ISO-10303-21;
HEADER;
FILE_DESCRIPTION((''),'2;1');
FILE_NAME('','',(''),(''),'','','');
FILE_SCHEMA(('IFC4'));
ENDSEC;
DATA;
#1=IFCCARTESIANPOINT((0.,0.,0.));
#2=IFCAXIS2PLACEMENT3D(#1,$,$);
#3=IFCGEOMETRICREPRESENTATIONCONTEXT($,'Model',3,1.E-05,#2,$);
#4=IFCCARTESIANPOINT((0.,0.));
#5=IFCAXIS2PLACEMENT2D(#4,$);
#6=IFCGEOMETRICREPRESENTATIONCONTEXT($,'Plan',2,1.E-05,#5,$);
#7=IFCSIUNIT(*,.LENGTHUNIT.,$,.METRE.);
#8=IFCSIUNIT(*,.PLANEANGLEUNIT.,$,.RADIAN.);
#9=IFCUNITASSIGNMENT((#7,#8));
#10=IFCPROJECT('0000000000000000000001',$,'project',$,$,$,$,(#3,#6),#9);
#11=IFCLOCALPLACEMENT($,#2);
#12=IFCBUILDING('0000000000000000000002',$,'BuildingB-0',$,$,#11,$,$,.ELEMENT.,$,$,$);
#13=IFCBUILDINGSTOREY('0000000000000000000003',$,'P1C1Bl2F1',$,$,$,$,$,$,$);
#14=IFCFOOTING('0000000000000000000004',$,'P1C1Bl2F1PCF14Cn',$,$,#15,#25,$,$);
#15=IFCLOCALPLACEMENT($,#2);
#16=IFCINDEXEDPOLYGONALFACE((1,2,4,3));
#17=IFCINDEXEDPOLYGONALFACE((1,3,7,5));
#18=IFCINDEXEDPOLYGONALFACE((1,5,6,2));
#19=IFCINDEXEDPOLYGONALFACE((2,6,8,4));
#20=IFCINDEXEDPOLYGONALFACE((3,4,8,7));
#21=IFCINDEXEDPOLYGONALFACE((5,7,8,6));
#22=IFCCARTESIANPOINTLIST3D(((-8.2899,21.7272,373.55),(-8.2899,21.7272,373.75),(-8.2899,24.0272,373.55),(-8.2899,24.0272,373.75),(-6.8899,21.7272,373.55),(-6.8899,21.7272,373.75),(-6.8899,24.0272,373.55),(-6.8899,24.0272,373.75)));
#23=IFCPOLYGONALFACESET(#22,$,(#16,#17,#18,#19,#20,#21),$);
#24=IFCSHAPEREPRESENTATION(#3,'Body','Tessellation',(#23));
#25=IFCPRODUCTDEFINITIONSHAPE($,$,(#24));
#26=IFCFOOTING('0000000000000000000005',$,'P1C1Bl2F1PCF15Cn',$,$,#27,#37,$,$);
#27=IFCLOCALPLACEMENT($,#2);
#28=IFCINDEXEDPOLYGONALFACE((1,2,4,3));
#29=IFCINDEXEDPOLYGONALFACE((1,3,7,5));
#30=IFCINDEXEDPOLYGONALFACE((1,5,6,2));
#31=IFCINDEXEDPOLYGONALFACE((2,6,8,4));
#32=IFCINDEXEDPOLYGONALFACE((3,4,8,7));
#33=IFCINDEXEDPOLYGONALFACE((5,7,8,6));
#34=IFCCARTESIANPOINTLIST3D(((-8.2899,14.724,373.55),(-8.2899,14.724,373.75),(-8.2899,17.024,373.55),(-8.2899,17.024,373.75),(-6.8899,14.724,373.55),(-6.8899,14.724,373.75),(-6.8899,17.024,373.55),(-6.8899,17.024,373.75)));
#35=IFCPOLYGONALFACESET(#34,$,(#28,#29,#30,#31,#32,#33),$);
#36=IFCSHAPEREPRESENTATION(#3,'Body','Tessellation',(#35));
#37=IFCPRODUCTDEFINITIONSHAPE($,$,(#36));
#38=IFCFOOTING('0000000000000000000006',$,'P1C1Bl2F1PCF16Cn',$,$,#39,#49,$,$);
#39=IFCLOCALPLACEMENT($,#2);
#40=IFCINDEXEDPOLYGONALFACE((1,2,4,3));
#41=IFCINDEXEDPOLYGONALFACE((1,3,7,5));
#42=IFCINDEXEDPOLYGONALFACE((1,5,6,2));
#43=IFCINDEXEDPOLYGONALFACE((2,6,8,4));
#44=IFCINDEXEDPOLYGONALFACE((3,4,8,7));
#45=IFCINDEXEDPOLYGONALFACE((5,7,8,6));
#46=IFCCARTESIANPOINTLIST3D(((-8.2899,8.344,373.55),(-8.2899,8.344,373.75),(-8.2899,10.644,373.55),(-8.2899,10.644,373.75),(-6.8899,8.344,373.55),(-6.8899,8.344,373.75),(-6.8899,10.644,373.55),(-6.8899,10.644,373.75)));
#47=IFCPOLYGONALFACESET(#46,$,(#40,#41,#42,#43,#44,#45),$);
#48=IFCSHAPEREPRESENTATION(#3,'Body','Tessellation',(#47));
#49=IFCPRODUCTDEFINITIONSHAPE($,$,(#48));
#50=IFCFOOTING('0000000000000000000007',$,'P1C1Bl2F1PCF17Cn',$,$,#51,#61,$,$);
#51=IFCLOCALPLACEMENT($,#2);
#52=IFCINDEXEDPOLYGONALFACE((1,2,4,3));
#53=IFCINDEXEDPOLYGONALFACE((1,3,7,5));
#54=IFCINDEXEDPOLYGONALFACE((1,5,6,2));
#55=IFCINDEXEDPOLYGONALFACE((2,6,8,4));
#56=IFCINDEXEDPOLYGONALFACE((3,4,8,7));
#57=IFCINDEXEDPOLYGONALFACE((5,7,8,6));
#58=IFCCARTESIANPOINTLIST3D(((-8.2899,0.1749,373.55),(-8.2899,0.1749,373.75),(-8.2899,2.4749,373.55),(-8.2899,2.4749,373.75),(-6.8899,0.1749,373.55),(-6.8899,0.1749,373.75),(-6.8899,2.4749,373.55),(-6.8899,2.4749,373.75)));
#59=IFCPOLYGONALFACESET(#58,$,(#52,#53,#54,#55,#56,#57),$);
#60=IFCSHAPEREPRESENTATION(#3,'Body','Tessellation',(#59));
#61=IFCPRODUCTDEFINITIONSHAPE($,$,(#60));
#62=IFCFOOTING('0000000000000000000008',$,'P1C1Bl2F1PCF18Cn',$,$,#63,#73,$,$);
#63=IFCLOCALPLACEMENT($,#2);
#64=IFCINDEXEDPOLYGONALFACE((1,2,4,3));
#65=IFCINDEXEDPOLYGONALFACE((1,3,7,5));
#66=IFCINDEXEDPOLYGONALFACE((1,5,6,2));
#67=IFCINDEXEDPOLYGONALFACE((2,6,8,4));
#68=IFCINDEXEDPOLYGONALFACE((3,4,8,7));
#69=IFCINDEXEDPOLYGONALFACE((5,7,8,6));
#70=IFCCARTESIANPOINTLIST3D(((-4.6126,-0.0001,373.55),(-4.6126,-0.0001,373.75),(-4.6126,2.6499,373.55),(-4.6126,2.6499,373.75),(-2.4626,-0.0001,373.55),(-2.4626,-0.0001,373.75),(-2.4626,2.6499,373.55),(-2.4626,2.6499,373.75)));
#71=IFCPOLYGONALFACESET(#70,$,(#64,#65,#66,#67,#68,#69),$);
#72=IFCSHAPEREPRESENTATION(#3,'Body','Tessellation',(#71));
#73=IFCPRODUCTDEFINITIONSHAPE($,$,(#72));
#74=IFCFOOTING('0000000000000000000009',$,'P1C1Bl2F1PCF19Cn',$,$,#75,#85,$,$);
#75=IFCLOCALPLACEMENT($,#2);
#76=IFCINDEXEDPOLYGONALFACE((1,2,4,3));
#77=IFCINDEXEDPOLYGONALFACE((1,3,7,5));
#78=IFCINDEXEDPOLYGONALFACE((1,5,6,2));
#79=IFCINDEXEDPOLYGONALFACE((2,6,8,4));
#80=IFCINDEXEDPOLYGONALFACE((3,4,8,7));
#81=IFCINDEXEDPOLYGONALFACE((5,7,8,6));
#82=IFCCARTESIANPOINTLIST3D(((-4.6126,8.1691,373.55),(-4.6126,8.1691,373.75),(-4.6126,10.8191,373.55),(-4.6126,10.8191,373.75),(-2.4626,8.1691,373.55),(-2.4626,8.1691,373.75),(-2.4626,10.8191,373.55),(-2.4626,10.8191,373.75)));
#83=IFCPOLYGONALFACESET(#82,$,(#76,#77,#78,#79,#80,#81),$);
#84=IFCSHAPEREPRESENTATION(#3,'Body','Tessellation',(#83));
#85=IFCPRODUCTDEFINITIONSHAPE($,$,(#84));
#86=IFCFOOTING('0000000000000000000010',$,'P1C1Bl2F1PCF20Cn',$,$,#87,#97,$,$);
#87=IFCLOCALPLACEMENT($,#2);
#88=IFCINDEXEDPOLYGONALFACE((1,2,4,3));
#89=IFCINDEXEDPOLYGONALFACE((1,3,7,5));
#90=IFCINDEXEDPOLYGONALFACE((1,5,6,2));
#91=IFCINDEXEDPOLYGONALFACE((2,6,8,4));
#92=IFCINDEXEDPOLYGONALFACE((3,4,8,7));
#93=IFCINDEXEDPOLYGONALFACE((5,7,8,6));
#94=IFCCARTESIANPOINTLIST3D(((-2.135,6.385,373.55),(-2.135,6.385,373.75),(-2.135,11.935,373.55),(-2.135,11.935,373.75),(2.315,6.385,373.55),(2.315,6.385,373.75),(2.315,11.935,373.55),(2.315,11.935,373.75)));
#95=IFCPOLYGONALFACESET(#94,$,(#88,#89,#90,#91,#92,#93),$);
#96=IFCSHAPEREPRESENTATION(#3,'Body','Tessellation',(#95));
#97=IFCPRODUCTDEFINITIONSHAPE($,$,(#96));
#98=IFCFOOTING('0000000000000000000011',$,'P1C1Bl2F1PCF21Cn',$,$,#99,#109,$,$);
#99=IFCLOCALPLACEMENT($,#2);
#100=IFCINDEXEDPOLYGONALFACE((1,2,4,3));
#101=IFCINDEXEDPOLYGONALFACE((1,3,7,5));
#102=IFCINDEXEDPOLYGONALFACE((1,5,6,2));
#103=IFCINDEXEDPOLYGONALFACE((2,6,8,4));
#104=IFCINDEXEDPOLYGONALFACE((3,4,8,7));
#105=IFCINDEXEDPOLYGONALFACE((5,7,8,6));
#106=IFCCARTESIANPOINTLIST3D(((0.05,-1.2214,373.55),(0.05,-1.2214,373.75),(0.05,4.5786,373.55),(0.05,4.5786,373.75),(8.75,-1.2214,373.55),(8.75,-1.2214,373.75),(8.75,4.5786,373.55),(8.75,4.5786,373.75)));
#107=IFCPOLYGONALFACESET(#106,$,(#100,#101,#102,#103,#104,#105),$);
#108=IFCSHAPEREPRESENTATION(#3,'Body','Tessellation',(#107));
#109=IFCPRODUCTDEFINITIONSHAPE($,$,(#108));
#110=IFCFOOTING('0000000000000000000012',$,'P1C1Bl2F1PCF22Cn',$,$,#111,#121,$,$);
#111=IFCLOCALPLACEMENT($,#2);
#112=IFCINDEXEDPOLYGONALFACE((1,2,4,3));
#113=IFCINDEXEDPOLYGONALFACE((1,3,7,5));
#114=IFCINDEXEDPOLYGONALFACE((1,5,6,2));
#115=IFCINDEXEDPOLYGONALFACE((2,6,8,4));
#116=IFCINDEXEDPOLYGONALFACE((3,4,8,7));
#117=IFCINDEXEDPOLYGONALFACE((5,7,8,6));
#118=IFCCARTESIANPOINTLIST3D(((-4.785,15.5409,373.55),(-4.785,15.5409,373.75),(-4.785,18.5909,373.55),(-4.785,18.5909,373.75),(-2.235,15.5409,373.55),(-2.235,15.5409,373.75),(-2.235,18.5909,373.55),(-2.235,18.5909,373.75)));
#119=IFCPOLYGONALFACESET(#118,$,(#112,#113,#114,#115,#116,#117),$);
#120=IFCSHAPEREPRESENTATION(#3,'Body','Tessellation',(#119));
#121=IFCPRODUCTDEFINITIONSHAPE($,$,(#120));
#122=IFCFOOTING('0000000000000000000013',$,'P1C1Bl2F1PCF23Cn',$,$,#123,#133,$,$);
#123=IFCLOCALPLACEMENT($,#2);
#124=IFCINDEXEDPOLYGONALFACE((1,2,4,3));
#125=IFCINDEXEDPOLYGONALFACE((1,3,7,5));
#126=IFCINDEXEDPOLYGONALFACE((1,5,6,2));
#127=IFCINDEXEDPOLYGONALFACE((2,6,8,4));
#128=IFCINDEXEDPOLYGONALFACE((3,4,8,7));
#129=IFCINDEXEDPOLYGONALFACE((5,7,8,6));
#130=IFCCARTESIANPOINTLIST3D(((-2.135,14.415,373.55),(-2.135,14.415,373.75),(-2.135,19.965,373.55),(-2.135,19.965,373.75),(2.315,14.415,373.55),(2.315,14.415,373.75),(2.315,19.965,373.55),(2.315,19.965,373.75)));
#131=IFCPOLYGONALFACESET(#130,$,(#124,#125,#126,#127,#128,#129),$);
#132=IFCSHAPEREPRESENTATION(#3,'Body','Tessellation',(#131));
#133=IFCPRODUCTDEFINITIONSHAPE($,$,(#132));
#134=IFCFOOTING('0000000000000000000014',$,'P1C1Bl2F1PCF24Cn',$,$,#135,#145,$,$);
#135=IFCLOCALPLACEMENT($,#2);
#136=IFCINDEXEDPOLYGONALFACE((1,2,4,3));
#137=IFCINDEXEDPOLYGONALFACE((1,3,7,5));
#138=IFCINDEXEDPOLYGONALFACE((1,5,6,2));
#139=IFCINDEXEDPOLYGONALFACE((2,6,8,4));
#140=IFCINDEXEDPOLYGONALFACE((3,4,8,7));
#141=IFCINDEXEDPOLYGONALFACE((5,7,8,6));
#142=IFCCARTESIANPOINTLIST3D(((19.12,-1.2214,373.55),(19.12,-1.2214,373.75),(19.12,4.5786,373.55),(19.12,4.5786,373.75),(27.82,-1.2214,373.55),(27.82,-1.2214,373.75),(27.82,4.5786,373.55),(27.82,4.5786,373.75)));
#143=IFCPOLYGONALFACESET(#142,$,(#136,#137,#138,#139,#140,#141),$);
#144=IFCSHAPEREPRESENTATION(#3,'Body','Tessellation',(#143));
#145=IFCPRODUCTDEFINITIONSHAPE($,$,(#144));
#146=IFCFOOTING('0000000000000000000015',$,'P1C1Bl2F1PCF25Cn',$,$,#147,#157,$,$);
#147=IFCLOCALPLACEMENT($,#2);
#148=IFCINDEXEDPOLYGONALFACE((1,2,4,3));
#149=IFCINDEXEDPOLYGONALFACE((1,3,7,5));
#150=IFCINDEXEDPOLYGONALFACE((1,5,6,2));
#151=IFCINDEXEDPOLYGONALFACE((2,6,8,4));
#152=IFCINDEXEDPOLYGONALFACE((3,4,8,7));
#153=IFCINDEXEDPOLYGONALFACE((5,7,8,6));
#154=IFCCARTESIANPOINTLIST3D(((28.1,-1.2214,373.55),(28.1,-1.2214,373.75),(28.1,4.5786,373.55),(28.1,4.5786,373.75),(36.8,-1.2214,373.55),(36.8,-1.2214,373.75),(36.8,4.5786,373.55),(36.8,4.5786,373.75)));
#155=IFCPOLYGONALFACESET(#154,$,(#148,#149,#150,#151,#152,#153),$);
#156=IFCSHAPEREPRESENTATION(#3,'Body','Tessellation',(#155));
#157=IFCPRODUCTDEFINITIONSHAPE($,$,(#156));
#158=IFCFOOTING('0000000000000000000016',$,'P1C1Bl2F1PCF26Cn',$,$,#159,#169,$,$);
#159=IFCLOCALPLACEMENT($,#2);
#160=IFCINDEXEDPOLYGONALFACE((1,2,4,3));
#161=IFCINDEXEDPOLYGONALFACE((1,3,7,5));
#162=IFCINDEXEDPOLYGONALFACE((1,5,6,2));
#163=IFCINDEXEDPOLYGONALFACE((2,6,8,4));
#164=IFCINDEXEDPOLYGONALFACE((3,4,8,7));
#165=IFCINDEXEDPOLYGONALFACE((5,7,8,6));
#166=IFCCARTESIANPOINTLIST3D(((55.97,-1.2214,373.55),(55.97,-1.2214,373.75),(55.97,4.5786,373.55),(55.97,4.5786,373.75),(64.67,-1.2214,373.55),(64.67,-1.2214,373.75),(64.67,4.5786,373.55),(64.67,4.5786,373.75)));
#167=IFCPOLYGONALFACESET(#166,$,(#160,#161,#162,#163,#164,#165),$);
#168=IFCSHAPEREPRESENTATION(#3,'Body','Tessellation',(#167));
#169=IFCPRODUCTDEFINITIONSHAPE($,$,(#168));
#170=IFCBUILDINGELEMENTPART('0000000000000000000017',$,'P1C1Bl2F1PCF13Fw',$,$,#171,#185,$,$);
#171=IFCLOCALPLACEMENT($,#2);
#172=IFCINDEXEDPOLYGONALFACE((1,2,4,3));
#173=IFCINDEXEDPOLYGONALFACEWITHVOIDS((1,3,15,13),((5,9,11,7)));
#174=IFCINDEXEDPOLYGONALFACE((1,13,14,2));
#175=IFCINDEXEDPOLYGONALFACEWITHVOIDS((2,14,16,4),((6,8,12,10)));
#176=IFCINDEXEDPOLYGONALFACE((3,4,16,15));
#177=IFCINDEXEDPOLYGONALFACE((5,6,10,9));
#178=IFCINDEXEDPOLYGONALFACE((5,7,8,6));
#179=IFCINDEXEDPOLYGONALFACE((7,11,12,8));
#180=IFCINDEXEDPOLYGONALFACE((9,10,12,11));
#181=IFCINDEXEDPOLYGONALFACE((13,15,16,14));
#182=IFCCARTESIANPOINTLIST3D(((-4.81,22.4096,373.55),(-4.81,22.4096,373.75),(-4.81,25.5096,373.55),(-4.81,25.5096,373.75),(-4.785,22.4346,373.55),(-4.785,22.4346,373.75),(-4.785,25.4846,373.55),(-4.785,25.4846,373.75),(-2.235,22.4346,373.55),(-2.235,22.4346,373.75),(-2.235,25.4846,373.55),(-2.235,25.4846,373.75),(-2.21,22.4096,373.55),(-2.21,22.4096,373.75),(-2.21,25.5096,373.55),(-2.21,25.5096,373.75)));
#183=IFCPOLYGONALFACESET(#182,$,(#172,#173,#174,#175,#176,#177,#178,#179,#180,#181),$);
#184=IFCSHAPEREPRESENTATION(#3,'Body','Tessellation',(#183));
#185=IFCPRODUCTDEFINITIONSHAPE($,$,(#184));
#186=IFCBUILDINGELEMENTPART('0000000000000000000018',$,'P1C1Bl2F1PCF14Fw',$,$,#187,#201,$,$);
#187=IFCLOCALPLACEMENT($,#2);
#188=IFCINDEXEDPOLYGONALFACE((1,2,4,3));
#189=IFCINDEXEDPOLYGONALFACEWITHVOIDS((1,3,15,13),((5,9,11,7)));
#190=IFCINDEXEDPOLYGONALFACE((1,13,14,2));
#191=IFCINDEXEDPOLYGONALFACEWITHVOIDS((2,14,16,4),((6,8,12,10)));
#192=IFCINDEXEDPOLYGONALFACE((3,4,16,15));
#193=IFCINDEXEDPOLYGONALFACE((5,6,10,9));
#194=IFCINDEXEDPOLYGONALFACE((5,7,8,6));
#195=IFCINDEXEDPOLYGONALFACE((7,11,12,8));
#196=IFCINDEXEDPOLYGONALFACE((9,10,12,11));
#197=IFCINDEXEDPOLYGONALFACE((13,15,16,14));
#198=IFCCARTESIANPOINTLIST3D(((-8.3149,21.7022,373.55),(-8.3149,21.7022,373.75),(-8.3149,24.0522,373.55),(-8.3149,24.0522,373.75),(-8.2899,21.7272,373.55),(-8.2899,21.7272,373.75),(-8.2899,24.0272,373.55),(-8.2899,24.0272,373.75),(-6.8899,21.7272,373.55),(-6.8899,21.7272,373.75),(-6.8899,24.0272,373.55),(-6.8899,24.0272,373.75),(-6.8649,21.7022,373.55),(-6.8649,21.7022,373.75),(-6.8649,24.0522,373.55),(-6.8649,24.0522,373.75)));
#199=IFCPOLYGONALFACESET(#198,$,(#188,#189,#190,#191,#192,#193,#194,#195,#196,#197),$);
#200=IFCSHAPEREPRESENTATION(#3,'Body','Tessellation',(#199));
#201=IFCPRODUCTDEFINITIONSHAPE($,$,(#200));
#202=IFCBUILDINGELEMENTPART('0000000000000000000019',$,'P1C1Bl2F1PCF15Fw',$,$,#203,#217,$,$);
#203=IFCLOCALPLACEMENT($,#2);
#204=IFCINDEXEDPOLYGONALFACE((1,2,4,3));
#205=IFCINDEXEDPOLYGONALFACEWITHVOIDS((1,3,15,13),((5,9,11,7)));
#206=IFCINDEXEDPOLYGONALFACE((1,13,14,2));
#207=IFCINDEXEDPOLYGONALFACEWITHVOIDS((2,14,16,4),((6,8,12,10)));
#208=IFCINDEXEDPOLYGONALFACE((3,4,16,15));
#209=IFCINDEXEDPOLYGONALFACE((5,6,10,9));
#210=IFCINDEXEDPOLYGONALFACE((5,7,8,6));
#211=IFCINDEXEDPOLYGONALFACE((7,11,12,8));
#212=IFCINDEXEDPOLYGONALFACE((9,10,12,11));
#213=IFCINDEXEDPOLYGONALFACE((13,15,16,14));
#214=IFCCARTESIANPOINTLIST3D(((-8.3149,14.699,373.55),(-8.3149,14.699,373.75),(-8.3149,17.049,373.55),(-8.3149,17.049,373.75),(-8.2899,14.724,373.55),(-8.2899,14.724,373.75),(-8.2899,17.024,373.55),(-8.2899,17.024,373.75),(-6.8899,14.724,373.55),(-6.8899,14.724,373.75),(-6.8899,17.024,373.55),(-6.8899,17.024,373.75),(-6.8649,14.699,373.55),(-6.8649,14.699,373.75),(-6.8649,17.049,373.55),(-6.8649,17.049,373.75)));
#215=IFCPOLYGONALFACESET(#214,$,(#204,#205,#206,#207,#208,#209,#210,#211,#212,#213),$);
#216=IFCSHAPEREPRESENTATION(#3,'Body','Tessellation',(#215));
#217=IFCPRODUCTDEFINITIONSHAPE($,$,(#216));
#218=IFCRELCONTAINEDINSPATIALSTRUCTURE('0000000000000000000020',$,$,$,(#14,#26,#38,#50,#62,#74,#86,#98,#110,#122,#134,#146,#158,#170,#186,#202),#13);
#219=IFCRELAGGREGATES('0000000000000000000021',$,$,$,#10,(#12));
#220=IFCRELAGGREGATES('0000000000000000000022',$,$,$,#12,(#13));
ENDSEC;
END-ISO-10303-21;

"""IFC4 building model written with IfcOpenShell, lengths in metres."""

from ifc_helpers import new_model, si_unit, origin, origin_2d, place, context, project, spatial, polyline, outline, extrude, element, save


model = new_model("IFC4")

# Units and contexts
model_context = context("Model", 3, precision=1e-05, world=origin())
plan_context = context("Plan", 2, precision=1e-05, world=origin_2d())
ifc_project = project(units=[si_unit("LENGTHUNIT", "METRE"), si_unit("PLANEANGLEUNIT", "RADIAN")], contexts=[model_context, plan_context])

# Building, storey
building_placement = place(None, origin())
building = spatial("IfcBuilding", under=ifc_project, at=building_placement, Name="BuildingB-0", CompositionType="ELEMENT")
storey = spatial("IfcBuildingStorey", under=building, Name="P1C1Bl2F1")

# Footings
element("IfcFooting", 1, inside=storey, Name="P1C1Bl2F1PCF14Cn", context=model_context, shape_type="SweptSolid", body=[
    extrude(outline(polyline([(-6.8899, 24.0272, 373.55), (-8.2899, 24.0272, 373.55), (-8.2899, 21.7272, 373.55), (-6.8899, 21.7272, 373.55), (-6.8899, 24.0272, 373.55)])), None, (0.0, 0.0, 1.0), 0.2),
])
element("IfcFooting", 2, inside=storey, Name="P1C1Bl2F1PCF15Cn", context=model_context, shape_type="SweptSolid", body=[
    extrude(outline(polyline([(-8.2899, 14.724, 373.55), (-6.8899, 14.724, 373.55), (-6.8899, 17.024, 373.55), (-8.2899, 17.024, 373.55), (-8.2899, 14.724, 373.55)])), None, (0.0, 0.0, 1.0), 0.2),
])
element("IfcFooting", 3, inside=storey, Name="P1C1Bl2F1PCF16Cn", context=model_context, shape_type="SweptSolid", body=[
    extrude(outline(polyline([(-8.2899, 8.344, 373.55), (-6.8899, 8.344, 373.55), (-6.8899, 10.644, 373.55), (-8.2899, 10.644, 373.55), (-8.2899, 8.344, 373.55)])), None, (0.0, 0.0, 1.0), 0.2),
])
element("IfcFooting", 4, inside=storey, Name="P1C1Bl2F1PCF17Cn", context=model_context, shape_type="SweptSolid", body=[
    extrude(outline(polyline([(-8.2899, 0.1749, 373.55), (-6.8899, 0.1749, 373.55), (-6.8899, 2.4749, 373.55), (-8.2899, 2.4749, 373.55), (-8.2899, 0.1749, 373.55)])), None, (0.0, 0.0, 1.0), 0.2),
])
element("IfcFooting", 5, inside=storey, Name="P1C1Bl2F1PCF18Cn", context=model_context, shape_type="SweptSolid", body=[
    extrude(outline(polyline([(-4.6126, -0.0001, 373.55), (-2.4626, -0.0001, 373.55), (-2.4626, 2.6499, 373.55), (-4.6126, 2.6499, 373.55), (-4.6126, -0.0001, 373.55)])), None, (0.0, 0.0, 1.0), 0.2),
])
element("IfcFooting", 6, inside=storey, Name="P1C1Bl2F1PCF19Cn", context=model_context, shape_type="SweptSolid", body=[
    extrude(outline(polyline([(-4.6126, 8.1691, 373.55), (-2.4626, 8.1691, 373.55), (-2.4626, 10.8191, 373.55), (-4.6126, 10.8191, 373.55), (-4.6126, 8.1691, 373.55)])), None, (0.0, 0.0, 1.0), 0.2),
])
element("IfcFooting", 7, inside=storey, Name="P1C1Bl2F1PCF20Cn", context=model_context, shape_type="SweptSolid", body=[
    extrude(outline(polyline([(-2.135, 6.385, 373.55), (2.315, 6.385, 373.55), (2.315, 11.935, 373.55), (-2.135, 11.935, 373.55), (-2.135, 6.385, 373.55)])), None, (0.0, 0.0, 1.0), 0.2),
])
element("IfcFooting", 8, inside=storey, Name="P1C1Bl2F1PCF21Cn", context=model_context, shape_type="SweptSolid", body=[
    extrude(outline(polyline([(0.05, -1.2214, 373.55), (8.75, -1.2214, 373.55), (8.75, 4.5786, 373.55), (0.05, 4.5786, 373.55), (0.05, -1.2214, 373.55)])), None, (0.0, 0.0, 1.0), 0.2),
])
element("IfcFooting", 9, inside=storey, Name="P1C1Bl2F1PCF22Cn", context=model_context, shape_type="SweptSolid", body=[
    extrude(outline(polyline([(-4.785, 15.5409, 373.55), (-2.235, 15.5409, 373.55), (-2.235, 18.5909, 373.55), (-4.785, 18.5909, 373.55), (-4.785, 15.5409, 373.55)])), None, (0.0, 0.0, 1.0), 0.2),
])
element("IfcFooting", 10, inside=storey, Name="P1C1Bl2F1PCF23Cn", context=model_context, shape_type="SweptSolid", body=[
    extrude(outline(polyline([(-2.135, 14.415, 373.55), (2.315, 14.415, 373.55), (2.315, 19.965, 373.55), (-2.135, 19.965, 373.55), (-2.135, 14.415, 373.55)])), None, (0.0, 0.0, 1.0), 0.2),
])
element("IfcFooting", 11, inside=storey, Name="P1C1Bl2F1PCF24Cn", context=model_context, shape_type="SweptSolid", body=[
    extrude(outline(polyline([(19.12, -1.2214, 373.55), (27.82, -1.2214, 373.55), (27.82, 4.5786, 373.55), (19.12, 4.5786, 373.55), (19.12, -1.2214, 373.55)])), None, (0.0, 0.0, 1.0), 0.2),
])
element("IfcFooting", 12, inside=storey, Name="P1C1Bl2F1PCF25Cn", context=model_context, shape_type="SweptSolid", body=[
    extrude(outline(polyline([(28.1, -1.2214, 373.55), (36.8, -1.2214, 373.55), (36.8, 4.5786, 373.55), (28.1, 4.5786, 373.55), (28.1, -1.2214, 373.55)])), None, (0.0, 0.0, 1.0), 0.2),
])
element("IfcFooting", 13, inside=storey, Name="P1C1Bl2F1PCF26Cn", context=model_context, shape_type="SweptSolid", body=[
    extrude(outline(polyline([(55.97, -1.2214, 373.55), (64.67, -1.2214, 373.55), (64.67, 4.5786, 373.55), (55.97, 4.5786, 373.55), (55.97, -1.2214, 373.55)])), None, (0.0, 0.0, 1.0), 0.2),
])

# Building element parts, openings
building_element_part_1 = element("IfcBuildingElementPart", 14, inside=storey, Name="P1C1Bl2F1PCF13Fw", context=model_context, shape_type="SweptSolid", body=[
    extrude(outline(polyline([(-2.21, 25.5096, 373.55), (-4.81, 25.5096, 373.55), (-4.81, 22.4096, 373.55), (-2.21, 22.4096, 373.55), (-2.21, 25.5096, 373.55)])), None, (0.0, 0.0, 1.0), 0.2),
])
element("IfcOpeningElement", 15, inside=storey, cuts=building_element_part_1, context=model_context, shape_type="SweptSolid", body=[
    extrude(outline(polyline([(-2.235, 25.4846, 373.55), (-4.785, 25.4846, 373.55), (-4.785, 22.4346, 373.55), (-2.235, 22.4346, 373.55), (-2.235, 25.4846, 373.55)])), None, (0.0, 0.0, 1.0), 0.2),
])
building_element_part_2 = element("IfcBuildingElementPart", 16, inside=storey, Name="P1C1Bl2F1PCF14Fw", context=model_context, shape_type="SweptSolid", body=[
    extrude(outline(polyline([(-6.8649, 24.0522, 373.55), (-8.3149, 24.0522, 373.55), (-8.3149, 21.7022, 373.55), (-6.8649, 21.7022, 373.55), (-6.8649, 24.0522, 373.55)])), None, (0.0, 0.0, 1.0), 0.2),
])
element("IfcOpeningElement", 17, inside=storey, cuts=building_element_part_2, context=model_context, shape_type="SweptSolid", body=[
    extrude(outline(polyline([(-6.8899, 24.0272, 373.55), (-8.2899, 24.0272, 373.55), (-8.2899, 21.7272, 373.55), (-6.8899, 21.7272, 373.55), (-6.8899, 24.0272, 373.55)])), None, (0.0, 0.0, 1.0), 0.2),
])
building_element_part_3 = element("IfcBuildingElementPart", 18, inside=storey, Name="P1C1Bl2F1PCF15Fw", context=model_context, shape_type="SweptSolid", body=[
    extrude(outline(polyline([(-8.3149, 14.699, 373.55), (-6.8649, 14.699, 373.55), (-6.8649, 17.049, 373.55), (-8.3149, 17.049, 373.55), (-8.3149, 14.699, 373.55)])), None, (0.0, 0.0, 1.0), 0.2),
])
element("IfcOpeningElement", 19, inside=storey, cuts=building_element_part_3, context=model_context, shape_type="SweptSolid", body=[
    extrude(outline(polyline([(-8.2899, 14.724, 373.55), (-6.8899, 14.724, 373.55), (-6.8899, 17.024, 373.55), (-8.2899, 17.024, 373.55), (-8.2899, 14.724, 373.55)])), None, (0.0, 0.0, 1.0), 0.2),
])

save(model, "model.ifc")
